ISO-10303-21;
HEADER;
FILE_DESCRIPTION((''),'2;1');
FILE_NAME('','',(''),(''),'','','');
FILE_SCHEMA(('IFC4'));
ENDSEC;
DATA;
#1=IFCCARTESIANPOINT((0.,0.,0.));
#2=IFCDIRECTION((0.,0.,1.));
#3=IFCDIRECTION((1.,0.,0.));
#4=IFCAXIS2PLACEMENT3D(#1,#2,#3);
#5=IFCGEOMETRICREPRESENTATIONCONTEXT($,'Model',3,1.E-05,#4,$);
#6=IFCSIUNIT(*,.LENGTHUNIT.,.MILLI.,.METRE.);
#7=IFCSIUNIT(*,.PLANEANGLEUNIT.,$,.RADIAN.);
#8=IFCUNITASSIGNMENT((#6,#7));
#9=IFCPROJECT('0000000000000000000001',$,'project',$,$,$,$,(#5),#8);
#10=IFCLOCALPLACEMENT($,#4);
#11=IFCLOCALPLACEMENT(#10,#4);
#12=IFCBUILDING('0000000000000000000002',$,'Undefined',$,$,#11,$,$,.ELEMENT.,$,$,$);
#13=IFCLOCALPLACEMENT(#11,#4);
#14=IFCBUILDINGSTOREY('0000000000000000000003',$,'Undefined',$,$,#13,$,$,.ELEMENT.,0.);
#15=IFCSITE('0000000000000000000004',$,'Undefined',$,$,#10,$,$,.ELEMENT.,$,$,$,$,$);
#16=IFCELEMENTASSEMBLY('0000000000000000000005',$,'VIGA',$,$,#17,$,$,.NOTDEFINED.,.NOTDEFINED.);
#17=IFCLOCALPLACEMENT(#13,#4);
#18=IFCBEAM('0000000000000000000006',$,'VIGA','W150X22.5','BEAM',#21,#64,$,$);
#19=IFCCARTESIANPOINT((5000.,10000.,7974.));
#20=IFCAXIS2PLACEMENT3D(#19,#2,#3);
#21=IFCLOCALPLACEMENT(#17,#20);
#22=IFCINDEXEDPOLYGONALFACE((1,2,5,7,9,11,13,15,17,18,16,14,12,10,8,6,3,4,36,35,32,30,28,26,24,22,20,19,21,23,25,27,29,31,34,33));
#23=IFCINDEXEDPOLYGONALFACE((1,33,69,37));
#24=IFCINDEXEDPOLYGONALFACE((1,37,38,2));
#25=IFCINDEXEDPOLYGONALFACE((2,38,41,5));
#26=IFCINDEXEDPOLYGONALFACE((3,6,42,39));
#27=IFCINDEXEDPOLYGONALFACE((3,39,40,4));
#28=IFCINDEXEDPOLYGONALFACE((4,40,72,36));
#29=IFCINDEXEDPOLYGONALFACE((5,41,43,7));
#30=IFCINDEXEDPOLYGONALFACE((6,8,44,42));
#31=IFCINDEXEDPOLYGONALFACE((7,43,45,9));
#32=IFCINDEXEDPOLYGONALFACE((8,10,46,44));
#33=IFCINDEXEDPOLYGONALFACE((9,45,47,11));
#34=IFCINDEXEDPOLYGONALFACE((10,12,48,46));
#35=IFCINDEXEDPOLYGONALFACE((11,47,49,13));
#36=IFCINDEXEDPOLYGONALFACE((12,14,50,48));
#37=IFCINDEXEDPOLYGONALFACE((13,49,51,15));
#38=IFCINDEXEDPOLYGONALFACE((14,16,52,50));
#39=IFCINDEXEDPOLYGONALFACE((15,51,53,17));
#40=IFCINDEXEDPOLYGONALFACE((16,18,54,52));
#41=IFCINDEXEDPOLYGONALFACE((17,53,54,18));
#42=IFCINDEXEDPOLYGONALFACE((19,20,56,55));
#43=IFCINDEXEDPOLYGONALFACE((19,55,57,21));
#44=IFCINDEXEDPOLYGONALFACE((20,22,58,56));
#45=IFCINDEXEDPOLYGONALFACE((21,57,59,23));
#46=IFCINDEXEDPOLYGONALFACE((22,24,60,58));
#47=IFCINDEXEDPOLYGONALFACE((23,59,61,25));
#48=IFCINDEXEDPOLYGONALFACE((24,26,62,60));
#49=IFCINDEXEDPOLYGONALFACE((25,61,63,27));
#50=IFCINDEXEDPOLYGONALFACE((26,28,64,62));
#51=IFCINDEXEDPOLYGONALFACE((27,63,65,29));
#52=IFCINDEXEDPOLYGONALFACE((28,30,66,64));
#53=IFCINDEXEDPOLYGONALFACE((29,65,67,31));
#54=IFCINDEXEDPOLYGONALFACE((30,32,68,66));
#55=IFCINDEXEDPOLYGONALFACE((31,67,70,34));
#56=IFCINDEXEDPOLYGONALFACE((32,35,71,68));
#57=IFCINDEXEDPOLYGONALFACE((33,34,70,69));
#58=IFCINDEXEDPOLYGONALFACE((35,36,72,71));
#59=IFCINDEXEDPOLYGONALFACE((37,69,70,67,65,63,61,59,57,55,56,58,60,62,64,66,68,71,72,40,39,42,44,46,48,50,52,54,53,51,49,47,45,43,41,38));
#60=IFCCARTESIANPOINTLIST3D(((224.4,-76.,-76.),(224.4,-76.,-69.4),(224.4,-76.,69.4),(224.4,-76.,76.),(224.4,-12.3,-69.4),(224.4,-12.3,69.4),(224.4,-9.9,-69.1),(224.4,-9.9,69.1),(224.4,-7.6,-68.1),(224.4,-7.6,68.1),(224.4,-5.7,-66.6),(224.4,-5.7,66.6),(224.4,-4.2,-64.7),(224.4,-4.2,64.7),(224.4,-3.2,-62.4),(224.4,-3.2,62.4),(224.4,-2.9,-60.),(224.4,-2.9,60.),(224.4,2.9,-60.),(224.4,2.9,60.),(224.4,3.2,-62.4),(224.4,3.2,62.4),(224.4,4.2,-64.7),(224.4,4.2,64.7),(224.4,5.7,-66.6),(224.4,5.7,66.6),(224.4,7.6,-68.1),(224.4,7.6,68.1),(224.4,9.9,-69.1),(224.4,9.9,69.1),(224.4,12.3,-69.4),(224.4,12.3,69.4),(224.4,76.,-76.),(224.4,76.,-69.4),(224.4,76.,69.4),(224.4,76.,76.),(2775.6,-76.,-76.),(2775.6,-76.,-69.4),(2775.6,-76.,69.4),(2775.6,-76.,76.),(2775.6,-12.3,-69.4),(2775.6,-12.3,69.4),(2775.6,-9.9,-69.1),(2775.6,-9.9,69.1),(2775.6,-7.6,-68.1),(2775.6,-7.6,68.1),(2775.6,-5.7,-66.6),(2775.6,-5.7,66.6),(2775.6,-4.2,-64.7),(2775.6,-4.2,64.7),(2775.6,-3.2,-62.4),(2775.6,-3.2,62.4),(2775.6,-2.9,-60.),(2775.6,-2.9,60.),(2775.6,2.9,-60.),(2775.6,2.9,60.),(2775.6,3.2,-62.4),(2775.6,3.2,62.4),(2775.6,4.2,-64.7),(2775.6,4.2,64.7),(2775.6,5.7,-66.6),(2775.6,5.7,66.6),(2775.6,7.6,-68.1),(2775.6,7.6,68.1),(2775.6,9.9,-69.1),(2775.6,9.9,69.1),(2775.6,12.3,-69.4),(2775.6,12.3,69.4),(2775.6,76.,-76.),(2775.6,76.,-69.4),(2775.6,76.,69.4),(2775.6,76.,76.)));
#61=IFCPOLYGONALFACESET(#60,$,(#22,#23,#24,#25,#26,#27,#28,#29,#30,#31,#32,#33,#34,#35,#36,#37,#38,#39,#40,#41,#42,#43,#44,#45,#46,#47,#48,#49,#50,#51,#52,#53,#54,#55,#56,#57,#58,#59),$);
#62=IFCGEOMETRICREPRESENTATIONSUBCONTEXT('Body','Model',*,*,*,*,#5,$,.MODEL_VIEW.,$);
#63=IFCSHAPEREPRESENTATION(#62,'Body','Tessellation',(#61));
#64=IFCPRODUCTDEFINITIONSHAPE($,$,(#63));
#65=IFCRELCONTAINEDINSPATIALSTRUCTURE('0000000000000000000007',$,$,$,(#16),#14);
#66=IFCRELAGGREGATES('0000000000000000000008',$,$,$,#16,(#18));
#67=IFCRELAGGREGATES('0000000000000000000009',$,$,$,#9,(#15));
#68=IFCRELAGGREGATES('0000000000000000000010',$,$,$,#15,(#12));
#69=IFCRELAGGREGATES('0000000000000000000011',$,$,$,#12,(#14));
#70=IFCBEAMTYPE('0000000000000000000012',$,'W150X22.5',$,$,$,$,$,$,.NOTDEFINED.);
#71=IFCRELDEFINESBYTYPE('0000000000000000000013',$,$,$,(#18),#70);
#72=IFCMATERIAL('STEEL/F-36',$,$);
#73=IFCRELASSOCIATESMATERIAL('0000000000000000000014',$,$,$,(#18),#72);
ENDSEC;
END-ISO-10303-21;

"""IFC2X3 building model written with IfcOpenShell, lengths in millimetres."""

from ifc_helpers import new_model, si_unit, frame, origin_with_axes, origin_2d_with_axis, place, context, subcontext, project, spatial, i_section, extrude, clip, halfspace, material, type_object, element, aggregate, save


model = new_model("IFC2X3")

# Units and contexts
model_context = context("Model", 3, precision=1e-05, world=origin_with_axes())
body_context = subcontext(model_context, "Body", "Model", "MODEL_VIEW")
ifc_project = project(units=[si_unit("LENGTHUNIT", "METRE", prefix="MILLI"), si_unit("PLANEANGLEUNIT", "RADIAN")], contexts=[model_context])

# Site, building, storey
site_placement = place(None, origin_with_axes())
site = spatial("IfcSite", under=ifc_project, at=site_placement, Name="Undefined", CompositionType="ELEMENT")
building_placement = place(site_placement, origin_with_axes())
building = spatial("IfcBuilding", under=site, at=building_placement, Name="Undefined", CompositionType="ELEMENT")
storey_placement = place(building_placement, origin_with_axes())
storey = spatial("IfcBuildingStorey", under=building, at=storey_placement, Name="Undefined", CompositionType="ELEMENT", Elevation=0.0)

# Element assembly, beam
assembly_1_placement = place(storey_placement, origin_with_axes())
assembly_1 = element("IfcElementAssembly", 1, at=assembly_1_placement, inside=storey, Name="VIGA", AssemblyPlace="NOTDEFINED", PredefinedType="NOTDEFINED")
ifc_material_1 = material(Name="STEEL/F-36")
beam_type_1 = type_object("IfcBeamType", Name="W150X22.5", PredefinedType="NOTDEFINED")
beam_1_placement = place(assembly_1_placement, frame((5000.0, 10000.0, 7974.0), z_axis=(0.0, 0.0, 1.0), x_axis=(1.0, 0.0, 0.0)))
beam_1 = element("IfcBeam", 2, at=beam_1_placement, type_object=beam_type_1, material=ifc_material_1, Name="VIGA", Description="W150X22.5", ObjectType="BEAM", context=body_context, shape_type="Clipping", body=[
    clip(clip(extrude(i_section(OverallWidth=152.0, OverallDepth=152.0, WebThickness=5.8, FlangeThickness=6.6, FilletRadius=9.4, at=origin_2d_with_axis()), frame((3000.0, 0.0, 0.0), z_axis=(-1.0, 0.0, 0.0), x_axis=(0.0, -1.0, 0.0)), (0.0, 0.0, 1.0), 3000.0), halfspace(frame((2775.6, 0.0, 0.0), z_axis=(-1.0, 0.0, 0.0), x_axis=(0.0, 1.0, 0.0)), True)), halfspace(frame((224.4, 0.0, 0.0), z_axis=(1.0, 0.0, -0.000002), x_axis=(0.0, -1.0, 0.0)), True)),
])
aggregate(assembly_1, [beam_1])

save(model, "model.ifc")
